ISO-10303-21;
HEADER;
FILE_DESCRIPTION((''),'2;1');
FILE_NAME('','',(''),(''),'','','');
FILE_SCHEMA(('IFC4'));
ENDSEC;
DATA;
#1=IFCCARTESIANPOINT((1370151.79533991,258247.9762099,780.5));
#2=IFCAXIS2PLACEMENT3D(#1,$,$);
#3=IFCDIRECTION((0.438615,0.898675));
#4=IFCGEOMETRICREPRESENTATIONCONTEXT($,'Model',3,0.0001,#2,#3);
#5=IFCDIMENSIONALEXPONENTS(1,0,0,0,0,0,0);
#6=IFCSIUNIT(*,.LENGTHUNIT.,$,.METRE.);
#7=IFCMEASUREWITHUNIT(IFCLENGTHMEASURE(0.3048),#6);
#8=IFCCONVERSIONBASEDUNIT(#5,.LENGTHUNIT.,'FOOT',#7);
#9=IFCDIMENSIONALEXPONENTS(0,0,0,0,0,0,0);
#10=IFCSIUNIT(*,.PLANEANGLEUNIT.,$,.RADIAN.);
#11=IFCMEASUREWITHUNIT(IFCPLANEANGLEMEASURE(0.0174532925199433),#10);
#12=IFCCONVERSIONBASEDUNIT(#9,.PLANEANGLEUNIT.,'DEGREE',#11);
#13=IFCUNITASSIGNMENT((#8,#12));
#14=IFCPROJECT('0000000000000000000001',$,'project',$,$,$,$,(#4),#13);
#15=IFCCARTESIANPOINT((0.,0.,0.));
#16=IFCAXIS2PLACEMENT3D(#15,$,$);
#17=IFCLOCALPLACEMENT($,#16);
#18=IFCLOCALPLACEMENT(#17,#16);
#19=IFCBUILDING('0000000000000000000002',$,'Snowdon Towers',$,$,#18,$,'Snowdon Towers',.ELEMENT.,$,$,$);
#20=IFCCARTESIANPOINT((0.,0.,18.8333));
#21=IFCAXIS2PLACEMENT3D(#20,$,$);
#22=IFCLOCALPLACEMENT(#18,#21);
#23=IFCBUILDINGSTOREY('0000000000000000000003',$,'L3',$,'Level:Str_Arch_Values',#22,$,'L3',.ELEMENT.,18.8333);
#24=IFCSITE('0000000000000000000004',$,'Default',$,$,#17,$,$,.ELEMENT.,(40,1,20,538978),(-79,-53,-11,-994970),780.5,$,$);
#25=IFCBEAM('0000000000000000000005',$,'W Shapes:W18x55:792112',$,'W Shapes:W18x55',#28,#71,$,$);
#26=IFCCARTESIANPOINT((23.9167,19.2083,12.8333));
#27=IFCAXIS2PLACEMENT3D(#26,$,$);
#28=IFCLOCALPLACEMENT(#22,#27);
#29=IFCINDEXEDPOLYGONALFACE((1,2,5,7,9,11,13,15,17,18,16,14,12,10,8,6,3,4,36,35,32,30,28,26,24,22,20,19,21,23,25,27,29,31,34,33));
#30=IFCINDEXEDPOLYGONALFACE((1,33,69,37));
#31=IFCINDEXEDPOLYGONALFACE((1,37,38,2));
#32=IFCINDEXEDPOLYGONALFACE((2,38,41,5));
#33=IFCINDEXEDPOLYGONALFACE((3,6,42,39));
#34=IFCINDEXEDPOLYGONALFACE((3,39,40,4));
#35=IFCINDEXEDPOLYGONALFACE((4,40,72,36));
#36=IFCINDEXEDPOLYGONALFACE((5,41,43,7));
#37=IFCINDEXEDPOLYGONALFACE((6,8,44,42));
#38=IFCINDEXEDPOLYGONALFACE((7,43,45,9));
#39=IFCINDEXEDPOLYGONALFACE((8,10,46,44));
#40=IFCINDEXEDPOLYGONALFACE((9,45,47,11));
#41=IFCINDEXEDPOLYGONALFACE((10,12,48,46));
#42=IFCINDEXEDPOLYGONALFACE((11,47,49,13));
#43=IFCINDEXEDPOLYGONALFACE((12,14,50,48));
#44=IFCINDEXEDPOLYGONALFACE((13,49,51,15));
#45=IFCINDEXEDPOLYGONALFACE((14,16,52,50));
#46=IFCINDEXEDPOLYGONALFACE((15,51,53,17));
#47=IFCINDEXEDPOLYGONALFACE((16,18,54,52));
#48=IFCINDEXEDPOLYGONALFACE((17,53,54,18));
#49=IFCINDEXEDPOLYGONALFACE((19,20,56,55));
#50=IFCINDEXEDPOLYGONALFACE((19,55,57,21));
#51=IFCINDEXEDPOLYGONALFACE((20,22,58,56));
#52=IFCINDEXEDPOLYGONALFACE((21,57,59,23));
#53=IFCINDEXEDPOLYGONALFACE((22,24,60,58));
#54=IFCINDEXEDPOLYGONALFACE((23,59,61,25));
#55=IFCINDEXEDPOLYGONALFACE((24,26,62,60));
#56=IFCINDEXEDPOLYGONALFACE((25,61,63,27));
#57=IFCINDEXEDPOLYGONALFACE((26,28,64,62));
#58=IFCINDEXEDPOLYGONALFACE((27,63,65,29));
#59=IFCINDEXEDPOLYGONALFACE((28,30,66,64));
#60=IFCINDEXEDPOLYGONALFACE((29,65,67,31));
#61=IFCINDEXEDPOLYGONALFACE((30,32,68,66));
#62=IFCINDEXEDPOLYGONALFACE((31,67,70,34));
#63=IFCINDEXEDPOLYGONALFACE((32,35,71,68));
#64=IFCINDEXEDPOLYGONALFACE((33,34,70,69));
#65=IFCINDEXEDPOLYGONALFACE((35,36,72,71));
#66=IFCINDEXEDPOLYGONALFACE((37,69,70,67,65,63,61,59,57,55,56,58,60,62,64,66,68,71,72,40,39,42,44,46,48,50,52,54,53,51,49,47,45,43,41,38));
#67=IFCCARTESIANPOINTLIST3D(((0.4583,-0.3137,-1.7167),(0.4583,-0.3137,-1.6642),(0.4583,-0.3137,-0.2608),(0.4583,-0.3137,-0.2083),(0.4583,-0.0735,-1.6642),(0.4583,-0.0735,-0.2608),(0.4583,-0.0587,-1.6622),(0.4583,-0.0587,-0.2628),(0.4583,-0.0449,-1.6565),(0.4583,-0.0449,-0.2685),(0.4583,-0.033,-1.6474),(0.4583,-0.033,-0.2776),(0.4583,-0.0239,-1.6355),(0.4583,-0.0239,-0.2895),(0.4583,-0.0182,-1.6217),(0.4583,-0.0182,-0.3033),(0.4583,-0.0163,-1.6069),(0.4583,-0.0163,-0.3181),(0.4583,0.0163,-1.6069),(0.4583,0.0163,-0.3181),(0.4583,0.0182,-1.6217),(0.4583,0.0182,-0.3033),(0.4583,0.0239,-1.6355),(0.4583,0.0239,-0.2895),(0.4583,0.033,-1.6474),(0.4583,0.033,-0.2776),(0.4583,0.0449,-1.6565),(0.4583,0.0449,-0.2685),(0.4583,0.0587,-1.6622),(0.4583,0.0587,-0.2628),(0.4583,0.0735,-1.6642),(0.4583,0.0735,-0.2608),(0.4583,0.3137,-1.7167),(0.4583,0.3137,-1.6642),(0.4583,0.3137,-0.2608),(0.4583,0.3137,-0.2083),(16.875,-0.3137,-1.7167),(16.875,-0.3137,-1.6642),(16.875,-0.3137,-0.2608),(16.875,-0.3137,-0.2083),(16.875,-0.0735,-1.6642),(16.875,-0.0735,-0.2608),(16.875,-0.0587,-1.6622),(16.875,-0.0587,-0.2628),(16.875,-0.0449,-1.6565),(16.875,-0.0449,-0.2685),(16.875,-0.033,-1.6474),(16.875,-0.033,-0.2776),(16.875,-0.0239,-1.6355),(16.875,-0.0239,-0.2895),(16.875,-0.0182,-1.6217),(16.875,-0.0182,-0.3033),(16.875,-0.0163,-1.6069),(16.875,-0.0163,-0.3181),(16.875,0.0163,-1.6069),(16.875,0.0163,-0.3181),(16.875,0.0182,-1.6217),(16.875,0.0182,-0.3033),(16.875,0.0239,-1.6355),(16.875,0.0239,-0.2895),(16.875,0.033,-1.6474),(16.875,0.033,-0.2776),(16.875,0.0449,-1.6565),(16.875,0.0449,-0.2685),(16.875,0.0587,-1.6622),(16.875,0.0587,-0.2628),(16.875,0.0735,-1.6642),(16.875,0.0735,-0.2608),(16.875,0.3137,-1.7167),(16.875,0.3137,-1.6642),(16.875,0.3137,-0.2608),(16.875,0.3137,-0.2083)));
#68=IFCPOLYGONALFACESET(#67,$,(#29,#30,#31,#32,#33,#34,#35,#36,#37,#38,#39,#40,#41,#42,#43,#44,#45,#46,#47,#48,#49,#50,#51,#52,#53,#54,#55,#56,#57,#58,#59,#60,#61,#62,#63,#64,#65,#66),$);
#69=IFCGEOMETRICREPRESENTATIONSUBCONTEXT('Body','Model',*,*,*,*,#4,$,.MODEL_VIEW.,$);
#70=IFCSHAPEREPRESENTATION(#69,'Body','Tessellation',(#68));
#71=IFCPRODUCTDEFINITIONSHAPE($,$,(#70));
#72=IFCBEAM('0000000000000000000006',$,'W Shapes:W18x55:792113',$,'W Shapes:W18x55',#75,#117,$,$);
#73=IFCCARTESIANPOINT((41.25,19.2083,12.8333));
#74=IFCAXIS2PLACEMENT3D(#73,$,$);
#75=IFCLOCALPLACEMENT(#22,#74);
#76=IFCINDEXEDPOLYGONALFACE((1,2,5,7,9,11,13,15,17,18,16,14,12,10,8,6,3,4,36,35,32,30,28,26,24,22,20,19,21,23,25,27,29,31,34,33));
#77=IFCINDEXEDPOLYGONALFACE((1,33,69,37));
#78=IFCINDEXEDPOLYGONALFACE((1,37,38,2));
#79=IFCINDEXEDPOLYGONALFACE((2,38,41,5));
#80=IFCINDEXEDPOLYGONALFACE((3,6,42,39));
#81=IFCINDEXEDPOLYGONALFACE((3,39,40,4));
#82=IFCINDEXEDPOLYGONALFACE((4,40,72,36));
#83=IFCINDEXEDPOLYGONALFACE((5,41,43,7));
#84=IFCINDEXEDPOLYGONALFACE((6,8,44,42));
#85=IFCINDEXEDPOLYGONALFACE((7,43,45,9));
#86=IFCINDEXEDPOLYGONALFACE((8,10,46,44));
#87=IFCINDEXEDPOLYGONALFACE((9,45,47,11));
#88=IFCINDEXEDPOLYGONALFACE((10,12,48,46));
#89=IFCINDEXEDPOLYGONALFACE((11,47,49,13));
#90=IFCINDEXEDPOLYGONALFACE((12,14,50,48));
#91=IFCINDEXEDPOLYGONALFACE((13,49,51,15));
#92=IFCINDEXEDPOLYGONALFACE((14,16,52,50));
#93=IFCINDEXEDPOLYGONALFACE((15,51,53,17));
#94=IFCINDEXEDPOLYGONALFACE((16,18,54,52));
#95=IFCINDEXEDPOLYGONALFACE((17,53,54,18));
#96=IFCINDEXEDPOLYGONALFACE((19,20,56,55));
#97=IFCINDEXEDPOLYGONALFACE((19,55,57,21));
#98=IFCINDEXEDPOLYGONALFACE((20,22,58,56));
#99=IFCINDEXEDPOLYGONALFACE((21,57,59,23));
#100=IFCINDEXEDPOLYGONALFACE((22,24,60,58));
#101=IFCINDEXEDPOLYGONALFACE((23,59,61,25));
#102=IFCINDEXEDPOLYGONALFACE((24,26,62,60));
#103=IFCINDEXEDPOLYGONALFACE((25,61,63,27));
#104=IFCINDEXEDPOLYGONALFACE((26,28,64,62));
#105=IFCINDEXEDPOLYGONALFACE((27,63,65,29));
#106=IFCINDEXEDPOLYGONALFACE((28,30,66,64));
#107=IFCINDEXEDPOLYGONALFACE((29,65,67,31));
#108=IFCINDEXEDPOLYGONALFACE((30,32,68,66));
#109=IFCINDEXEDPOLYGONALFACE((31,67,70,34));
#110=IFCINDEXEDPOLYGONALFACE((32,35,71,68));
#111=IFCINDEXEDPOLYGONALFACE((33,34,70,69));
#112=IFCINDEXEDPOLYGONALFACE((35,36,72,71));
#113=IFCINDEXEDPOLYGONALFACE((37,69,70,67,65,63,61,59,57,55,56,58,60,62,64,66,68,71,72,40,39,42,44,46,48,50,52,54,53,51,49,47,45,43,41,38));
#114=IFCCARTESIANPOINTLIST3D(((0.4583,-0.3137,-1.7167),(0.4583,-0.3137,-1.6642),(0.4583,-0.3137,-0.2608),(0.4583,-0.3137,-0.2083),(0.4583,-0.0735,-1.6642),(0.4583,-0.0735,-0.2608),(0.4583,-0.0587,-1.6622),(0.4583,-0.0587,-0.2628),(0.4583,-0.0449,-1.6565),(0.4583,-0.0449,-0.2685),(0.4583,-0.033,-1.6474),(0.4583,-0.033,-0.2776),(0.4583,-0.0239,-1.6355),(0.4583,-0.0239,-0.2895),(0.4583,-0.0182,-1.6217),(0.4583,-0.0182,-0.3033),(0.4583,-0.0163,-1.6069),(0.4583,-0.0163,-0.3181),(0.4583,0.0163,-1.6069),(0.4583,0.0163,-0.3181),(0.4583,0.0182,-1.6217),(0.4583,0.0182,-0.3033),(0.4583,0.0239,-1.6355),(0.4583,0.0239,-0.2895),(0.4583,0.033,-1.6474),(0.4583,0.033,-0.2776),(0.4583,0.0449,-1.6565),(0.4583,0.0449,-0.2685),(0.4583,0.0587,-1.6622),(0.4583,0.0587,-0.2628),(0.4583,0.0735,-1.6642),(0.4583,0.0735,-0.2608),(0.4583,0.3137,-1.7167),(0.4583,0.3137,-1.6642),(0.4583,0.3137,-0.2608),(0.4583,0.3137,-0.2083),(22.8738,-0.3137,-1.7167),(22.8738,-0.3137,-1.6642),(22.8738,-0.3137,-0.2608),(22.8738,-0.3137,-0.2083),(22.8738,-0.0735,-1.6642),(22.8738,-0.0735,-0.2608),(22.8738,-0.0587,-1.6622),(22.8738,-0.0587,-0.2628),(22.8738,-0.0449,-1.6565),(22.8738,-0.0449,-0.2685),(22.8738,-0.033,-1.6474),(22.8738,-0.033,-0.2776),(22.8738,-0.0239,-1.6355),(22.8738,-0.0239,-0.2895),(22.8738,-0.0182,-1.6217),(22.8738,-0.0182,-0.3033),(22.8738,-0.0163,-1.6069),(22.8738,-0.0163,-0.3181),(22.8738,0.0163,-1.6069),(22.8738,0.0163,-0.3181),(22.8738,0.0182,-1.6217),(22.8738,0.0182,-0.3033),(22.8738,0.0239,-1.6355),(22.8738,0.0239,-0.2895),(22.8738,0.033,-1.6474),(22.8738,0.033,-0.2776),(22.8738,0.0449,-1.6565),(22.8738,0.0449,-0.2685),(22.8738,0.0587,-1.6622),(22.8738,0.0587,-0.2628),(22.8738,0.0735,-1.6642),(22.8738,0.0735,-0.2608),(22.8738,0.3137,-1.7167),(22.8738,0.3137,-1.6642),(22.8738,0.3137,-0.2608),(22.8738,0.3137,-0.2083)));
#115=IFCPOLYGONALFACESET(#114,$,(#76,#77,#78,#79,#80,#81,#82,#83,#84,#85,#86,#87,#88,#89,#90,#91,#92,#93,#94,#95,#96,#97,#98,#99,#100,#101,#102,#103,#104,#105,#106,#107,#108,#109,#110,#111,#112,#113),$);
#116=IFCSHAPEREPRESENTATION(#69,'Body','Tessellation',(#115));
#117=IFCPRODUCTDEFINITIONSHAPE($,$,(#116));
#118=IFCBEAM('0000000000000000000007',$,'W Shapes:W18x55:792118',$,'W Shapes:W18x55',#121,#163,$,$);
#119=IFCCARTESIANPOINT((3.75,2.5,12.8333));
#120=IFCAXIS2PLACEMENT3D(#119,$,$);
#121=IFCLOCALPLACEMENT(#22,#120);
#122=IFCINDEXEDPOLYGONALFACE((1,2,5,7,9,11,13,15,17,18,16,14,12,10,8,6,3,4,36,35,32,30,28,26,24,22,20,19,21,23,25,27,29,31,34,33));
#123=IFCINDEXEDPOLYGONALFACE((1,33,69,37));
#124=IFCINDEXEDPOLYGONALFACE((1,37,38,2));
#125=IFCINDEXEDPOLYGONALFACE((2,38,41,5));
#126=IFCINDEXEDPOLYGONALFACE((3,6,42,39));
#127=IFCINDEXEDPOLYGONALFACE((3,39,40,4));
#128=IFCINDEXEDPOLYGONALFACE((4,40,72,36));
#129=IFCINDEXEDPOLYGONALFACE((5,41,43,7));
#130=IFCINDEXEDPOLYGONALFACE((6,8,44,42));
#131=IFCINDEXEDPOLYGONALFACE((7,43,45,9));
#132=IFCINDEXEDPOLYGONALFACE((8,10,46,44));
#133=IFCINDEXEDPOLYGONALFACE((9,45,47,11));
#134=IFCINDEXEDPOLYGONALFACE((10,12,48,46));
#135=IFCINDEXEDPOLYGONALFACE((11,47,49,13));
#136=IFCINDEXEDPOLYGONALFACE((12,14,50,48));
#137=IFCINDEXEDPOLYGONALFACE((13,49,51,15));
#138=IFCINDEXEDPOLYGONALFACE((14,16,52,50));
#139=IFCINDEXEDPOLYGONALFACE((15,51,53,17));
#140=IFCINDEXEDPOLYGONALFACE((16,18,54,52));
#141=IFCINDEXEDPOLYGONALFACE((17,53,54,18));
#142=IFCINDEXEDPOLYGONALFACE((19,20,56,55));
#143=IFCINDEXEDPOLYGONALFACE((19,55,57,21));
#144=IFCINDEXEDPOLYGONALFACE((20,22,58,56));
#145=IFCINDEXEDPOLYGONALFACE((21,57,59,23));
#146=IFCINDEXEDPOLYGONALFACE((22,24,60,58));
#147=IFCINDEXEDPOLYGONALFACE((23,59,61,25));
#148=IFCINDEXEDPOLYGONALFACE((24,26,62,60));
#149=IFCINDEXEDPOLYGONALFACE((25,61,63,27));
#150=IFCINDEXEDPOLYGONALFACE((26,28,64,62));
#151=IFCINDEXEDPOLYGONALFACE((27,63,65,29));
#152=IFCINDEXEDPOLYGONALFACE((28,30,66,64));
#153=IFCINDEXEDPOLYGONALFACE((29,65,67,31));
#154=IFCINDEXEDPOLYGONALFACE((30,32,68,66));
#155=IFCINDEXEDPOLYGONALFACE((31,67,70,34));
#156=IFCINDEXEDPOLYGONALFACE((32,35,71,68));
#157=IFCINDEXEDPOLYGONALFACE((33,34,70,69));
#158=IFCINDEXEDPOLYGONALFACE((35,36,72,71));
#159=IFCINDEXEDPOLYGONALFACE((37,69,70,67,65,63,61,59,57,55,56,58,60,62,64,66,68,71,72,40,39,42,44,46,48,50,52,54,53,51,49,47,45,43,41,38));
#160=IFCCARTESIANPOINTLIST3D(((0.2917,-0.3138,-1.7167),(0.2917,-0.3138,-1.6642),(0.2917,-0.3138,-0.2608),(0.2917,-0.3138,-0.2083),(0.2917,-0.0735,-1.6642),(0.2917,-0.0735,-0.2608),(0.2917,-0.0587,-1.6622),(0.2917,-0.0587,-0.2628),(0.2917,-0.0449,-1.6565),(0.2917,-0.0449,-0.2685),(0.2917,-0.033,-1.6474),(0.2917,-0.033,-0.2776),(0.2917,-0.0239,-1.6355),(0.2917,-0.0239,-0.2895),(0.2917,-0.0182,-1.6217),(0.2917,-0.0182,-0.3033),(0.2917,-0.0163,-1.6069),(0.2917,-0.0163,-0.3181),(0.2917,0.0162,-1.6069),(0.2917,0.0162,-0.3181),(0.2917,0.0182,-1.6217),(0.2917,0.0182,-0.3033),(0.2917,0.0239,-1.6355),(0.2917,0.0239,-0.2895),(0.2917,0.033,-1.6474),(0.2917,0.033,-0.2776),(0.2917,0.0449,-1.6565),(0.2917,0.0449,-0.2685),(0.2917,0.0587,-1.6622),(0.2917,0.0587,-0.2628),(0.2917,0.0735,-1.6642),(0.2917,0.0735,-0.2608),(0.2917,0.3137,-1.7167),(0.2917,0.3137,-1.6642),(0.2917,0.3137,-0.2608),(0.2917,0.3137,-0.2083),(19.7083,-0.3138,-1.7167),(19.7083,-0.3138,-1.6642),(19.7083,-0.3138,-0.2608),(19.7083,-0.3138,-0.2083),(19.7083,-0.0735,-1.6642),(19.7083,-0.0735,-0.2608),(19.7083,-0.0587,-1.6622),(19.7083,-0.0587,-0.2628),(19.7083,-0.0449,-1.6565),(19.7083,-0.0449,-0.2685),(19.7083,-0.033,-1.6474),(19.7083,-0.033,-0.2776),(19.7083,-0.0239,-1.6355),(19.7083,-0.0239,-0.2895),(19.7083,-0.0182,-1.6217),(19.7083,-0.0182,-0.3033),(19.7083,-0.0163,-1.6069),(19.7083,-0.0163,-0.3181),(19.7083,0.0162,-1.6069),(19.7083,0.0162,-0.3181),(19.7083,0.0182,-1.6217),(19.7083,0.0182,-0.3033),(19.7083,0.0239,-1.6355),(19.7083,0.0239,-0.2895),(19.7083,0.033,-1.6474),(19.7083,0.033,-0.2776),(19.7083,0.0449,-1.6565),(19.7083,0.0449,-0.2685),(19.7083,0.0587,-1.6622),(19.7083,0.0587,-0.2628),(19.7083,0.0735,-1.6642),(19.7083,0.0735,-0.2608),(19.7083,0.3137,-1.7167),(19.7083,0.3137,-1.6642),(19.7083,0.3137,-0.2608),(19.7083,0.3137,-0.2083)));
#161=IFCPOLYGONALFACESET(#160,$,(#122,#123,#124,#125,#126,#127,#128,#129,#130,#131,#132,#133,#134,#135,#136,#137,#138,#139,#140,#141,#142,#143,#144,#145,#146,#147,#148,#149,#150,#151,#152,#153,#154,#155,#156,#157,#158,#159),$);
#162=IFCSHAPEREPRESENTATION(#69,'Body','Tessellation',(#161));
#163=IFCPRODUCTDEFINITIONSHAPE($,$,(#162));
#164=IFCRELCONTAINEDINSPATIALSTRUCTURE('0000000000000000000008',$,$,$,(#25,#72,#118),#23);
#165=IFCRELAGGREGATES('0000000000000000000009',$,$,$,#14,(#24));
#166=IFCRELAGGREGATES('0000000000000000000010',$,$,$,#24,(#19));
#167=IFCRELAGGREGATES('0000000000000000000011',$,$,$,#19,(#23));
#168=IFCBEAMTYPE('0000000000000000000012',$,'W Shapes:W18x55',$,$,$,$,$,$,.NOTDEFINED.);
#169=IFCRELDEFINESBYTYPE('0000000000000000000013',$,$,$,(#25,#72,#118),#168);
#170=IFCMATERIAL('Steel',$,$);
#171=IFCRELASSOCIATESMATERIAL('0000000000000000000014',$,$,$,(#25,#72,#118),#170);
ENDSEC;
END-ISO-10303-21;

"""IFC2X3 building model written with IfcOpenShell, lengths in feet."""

from ifc_helpers import new_model, entity, si_unit, converted_unit, direction, frame, frame_2d, origin, place, context, subcontext, project, spatial, i_section, extrude, material, type_object, element, save


model = new_model("IFC2X3")

# Units and contexts
model_context = context("Model", 3, precision=0.0001, world=frame((1370151.79533991, 258247.9762099, 780.5)), true_north=direction((0.438615, 0.898675)))
body_context = subcontext(model_context, "Body", "Model", "MODEL_VIEW")
ifc_project = project(units=[converted_unit("LENGTHUNIT", "FOOT", entity("IfcLengthMeasure", 0.3048), si_unit("LENGTHUNIT", "METRE"), dimensions=[1, 0, 0, 0, 0, 0, 0]), converted_unit("PLANEANGLEUNIT", "DEGREE", entity("IfcPlaneAngleMeasure", 0.0174532925199433), si_unit("PLANEANGLEUNIT", "RADIAN"), dimensions=[0, 0, 0, 0, 0, 0, 0])], contexts=[model_context])

# Site, building, storey
site_placement = place(None, origin())
site = spatial("IfcSite", under=ifc_project, at=site_placement, Name="Default", CompositionType="ELEMENT", RefLatitude=(40, 1, 20, 538978), RefLongitude=(-79, -53, -11, -994970), RefElevation=780.5)
building_placement = place(site_placement, origin())
building = spatial("IfcBuilding", under=site, at=building_placement, Name="Snowdon Towers", LongName="Snowdon Towers", CompositionType="ELEMENT")
storey_placement = place(building_placement, frame((0.0, 0.0, 18.8333)))
storey = spatial("IfcBuildingStorey", under=building, at=storey_placement, Name="L3", ObjectType="Level:Str_Arch_Values", LongName="L3", CompositionType="ELEMENT", Elevation=18.8333)

# Beams
ifc_material = material(Name="Steel")
beam_type_1 = type_object("IfcBeamType", Name="W Shapes:W18x55", PredefinedType="NOTDEFINED")
beam_1_placement = place(storey_placement, frame((23.9167, 19.2083, 12.8333)))
element("IfcBeam", 1, at=beam_1_placement, inside=storey, type_object=beam_type_1, material=ifc_material, Name="W Shapes:W18x55:792112", ObjectType="W Shapes:W18x55", context=body_context, shape_type="SweptSolid", body=[
    extrude(i_section(OverallWidth=0.6275, OverallDepth=1.5083, WebThickness=0.0325, FlangeThickness=0.0525, FilletRadius=0.0573, at=frame_2d((0.0, 0.0), x_axis=(0.0, 1.0))), frame((0.4583, 0.0, -0.9625), z_axis=(1.0, 0.0, 0.0), x_axis=(0.0, 0.0, -1.0)), (0.0, 0.0, 1.0), 16.4167),
])
beam_2_placement = place(storey_placement, frame((41.25, 19.2083, 12.8333)))
element("IfcBeam", 2, at=beam_2_placement, inside=storey, type_object=beam_type_1, material=ifc_material, Name="W Shapes:W18x55:792113", ObjectType="W Shapes:W18x55", context=body_context, shape_type="SweptSolid", body=[
    extrude(i_section(OverallWidth=0.6275, OverallDepth=1.5083, WebThickness=0.0325, FlangeThickness=0.0525, FilletRadius=0.0573, at=frame_2d((0.0, 0.0), x_axis=(0.0, 1.0))), frame((0.4583, 0.0, -0.9625), z_axis=(1.0, 0.0, 0.0), x_axis=(0.0, 0.0, -1.0)), (0.0, 0.0, 1.0), 22.4154),
])
beam_3_placement = place(storey_placement, frame((3.75, 2.5, 12.8333)))
element("IfcBeam", 3, at=beam_3_placement, inside=storey, type_object=beam_type_1, material=ifc_material, Name="W Shapes:W18x55:792118", ObjectType="W Shapes:W18x55", context=body_context, shape_type="SweptSolid", body=[
    extrude(i_section(OverallWidth=0.6275, OverallDepth=1.5083, WebThickness=0.0325, FlangeThickness=0.0525, FilletRadius=0.0573, at=frame_2d((0.0, 0.0), x_axis=(0.0, 1.0))), frame((0.2917, 0.0, -0.9625), z_axis=(1.0, 0.0, 0.0), x_axis=(0.0, 0.0, -1.0)), (0.0, 0.0, 1.0), 19.4167),
])

save(model, "model.ifc")
